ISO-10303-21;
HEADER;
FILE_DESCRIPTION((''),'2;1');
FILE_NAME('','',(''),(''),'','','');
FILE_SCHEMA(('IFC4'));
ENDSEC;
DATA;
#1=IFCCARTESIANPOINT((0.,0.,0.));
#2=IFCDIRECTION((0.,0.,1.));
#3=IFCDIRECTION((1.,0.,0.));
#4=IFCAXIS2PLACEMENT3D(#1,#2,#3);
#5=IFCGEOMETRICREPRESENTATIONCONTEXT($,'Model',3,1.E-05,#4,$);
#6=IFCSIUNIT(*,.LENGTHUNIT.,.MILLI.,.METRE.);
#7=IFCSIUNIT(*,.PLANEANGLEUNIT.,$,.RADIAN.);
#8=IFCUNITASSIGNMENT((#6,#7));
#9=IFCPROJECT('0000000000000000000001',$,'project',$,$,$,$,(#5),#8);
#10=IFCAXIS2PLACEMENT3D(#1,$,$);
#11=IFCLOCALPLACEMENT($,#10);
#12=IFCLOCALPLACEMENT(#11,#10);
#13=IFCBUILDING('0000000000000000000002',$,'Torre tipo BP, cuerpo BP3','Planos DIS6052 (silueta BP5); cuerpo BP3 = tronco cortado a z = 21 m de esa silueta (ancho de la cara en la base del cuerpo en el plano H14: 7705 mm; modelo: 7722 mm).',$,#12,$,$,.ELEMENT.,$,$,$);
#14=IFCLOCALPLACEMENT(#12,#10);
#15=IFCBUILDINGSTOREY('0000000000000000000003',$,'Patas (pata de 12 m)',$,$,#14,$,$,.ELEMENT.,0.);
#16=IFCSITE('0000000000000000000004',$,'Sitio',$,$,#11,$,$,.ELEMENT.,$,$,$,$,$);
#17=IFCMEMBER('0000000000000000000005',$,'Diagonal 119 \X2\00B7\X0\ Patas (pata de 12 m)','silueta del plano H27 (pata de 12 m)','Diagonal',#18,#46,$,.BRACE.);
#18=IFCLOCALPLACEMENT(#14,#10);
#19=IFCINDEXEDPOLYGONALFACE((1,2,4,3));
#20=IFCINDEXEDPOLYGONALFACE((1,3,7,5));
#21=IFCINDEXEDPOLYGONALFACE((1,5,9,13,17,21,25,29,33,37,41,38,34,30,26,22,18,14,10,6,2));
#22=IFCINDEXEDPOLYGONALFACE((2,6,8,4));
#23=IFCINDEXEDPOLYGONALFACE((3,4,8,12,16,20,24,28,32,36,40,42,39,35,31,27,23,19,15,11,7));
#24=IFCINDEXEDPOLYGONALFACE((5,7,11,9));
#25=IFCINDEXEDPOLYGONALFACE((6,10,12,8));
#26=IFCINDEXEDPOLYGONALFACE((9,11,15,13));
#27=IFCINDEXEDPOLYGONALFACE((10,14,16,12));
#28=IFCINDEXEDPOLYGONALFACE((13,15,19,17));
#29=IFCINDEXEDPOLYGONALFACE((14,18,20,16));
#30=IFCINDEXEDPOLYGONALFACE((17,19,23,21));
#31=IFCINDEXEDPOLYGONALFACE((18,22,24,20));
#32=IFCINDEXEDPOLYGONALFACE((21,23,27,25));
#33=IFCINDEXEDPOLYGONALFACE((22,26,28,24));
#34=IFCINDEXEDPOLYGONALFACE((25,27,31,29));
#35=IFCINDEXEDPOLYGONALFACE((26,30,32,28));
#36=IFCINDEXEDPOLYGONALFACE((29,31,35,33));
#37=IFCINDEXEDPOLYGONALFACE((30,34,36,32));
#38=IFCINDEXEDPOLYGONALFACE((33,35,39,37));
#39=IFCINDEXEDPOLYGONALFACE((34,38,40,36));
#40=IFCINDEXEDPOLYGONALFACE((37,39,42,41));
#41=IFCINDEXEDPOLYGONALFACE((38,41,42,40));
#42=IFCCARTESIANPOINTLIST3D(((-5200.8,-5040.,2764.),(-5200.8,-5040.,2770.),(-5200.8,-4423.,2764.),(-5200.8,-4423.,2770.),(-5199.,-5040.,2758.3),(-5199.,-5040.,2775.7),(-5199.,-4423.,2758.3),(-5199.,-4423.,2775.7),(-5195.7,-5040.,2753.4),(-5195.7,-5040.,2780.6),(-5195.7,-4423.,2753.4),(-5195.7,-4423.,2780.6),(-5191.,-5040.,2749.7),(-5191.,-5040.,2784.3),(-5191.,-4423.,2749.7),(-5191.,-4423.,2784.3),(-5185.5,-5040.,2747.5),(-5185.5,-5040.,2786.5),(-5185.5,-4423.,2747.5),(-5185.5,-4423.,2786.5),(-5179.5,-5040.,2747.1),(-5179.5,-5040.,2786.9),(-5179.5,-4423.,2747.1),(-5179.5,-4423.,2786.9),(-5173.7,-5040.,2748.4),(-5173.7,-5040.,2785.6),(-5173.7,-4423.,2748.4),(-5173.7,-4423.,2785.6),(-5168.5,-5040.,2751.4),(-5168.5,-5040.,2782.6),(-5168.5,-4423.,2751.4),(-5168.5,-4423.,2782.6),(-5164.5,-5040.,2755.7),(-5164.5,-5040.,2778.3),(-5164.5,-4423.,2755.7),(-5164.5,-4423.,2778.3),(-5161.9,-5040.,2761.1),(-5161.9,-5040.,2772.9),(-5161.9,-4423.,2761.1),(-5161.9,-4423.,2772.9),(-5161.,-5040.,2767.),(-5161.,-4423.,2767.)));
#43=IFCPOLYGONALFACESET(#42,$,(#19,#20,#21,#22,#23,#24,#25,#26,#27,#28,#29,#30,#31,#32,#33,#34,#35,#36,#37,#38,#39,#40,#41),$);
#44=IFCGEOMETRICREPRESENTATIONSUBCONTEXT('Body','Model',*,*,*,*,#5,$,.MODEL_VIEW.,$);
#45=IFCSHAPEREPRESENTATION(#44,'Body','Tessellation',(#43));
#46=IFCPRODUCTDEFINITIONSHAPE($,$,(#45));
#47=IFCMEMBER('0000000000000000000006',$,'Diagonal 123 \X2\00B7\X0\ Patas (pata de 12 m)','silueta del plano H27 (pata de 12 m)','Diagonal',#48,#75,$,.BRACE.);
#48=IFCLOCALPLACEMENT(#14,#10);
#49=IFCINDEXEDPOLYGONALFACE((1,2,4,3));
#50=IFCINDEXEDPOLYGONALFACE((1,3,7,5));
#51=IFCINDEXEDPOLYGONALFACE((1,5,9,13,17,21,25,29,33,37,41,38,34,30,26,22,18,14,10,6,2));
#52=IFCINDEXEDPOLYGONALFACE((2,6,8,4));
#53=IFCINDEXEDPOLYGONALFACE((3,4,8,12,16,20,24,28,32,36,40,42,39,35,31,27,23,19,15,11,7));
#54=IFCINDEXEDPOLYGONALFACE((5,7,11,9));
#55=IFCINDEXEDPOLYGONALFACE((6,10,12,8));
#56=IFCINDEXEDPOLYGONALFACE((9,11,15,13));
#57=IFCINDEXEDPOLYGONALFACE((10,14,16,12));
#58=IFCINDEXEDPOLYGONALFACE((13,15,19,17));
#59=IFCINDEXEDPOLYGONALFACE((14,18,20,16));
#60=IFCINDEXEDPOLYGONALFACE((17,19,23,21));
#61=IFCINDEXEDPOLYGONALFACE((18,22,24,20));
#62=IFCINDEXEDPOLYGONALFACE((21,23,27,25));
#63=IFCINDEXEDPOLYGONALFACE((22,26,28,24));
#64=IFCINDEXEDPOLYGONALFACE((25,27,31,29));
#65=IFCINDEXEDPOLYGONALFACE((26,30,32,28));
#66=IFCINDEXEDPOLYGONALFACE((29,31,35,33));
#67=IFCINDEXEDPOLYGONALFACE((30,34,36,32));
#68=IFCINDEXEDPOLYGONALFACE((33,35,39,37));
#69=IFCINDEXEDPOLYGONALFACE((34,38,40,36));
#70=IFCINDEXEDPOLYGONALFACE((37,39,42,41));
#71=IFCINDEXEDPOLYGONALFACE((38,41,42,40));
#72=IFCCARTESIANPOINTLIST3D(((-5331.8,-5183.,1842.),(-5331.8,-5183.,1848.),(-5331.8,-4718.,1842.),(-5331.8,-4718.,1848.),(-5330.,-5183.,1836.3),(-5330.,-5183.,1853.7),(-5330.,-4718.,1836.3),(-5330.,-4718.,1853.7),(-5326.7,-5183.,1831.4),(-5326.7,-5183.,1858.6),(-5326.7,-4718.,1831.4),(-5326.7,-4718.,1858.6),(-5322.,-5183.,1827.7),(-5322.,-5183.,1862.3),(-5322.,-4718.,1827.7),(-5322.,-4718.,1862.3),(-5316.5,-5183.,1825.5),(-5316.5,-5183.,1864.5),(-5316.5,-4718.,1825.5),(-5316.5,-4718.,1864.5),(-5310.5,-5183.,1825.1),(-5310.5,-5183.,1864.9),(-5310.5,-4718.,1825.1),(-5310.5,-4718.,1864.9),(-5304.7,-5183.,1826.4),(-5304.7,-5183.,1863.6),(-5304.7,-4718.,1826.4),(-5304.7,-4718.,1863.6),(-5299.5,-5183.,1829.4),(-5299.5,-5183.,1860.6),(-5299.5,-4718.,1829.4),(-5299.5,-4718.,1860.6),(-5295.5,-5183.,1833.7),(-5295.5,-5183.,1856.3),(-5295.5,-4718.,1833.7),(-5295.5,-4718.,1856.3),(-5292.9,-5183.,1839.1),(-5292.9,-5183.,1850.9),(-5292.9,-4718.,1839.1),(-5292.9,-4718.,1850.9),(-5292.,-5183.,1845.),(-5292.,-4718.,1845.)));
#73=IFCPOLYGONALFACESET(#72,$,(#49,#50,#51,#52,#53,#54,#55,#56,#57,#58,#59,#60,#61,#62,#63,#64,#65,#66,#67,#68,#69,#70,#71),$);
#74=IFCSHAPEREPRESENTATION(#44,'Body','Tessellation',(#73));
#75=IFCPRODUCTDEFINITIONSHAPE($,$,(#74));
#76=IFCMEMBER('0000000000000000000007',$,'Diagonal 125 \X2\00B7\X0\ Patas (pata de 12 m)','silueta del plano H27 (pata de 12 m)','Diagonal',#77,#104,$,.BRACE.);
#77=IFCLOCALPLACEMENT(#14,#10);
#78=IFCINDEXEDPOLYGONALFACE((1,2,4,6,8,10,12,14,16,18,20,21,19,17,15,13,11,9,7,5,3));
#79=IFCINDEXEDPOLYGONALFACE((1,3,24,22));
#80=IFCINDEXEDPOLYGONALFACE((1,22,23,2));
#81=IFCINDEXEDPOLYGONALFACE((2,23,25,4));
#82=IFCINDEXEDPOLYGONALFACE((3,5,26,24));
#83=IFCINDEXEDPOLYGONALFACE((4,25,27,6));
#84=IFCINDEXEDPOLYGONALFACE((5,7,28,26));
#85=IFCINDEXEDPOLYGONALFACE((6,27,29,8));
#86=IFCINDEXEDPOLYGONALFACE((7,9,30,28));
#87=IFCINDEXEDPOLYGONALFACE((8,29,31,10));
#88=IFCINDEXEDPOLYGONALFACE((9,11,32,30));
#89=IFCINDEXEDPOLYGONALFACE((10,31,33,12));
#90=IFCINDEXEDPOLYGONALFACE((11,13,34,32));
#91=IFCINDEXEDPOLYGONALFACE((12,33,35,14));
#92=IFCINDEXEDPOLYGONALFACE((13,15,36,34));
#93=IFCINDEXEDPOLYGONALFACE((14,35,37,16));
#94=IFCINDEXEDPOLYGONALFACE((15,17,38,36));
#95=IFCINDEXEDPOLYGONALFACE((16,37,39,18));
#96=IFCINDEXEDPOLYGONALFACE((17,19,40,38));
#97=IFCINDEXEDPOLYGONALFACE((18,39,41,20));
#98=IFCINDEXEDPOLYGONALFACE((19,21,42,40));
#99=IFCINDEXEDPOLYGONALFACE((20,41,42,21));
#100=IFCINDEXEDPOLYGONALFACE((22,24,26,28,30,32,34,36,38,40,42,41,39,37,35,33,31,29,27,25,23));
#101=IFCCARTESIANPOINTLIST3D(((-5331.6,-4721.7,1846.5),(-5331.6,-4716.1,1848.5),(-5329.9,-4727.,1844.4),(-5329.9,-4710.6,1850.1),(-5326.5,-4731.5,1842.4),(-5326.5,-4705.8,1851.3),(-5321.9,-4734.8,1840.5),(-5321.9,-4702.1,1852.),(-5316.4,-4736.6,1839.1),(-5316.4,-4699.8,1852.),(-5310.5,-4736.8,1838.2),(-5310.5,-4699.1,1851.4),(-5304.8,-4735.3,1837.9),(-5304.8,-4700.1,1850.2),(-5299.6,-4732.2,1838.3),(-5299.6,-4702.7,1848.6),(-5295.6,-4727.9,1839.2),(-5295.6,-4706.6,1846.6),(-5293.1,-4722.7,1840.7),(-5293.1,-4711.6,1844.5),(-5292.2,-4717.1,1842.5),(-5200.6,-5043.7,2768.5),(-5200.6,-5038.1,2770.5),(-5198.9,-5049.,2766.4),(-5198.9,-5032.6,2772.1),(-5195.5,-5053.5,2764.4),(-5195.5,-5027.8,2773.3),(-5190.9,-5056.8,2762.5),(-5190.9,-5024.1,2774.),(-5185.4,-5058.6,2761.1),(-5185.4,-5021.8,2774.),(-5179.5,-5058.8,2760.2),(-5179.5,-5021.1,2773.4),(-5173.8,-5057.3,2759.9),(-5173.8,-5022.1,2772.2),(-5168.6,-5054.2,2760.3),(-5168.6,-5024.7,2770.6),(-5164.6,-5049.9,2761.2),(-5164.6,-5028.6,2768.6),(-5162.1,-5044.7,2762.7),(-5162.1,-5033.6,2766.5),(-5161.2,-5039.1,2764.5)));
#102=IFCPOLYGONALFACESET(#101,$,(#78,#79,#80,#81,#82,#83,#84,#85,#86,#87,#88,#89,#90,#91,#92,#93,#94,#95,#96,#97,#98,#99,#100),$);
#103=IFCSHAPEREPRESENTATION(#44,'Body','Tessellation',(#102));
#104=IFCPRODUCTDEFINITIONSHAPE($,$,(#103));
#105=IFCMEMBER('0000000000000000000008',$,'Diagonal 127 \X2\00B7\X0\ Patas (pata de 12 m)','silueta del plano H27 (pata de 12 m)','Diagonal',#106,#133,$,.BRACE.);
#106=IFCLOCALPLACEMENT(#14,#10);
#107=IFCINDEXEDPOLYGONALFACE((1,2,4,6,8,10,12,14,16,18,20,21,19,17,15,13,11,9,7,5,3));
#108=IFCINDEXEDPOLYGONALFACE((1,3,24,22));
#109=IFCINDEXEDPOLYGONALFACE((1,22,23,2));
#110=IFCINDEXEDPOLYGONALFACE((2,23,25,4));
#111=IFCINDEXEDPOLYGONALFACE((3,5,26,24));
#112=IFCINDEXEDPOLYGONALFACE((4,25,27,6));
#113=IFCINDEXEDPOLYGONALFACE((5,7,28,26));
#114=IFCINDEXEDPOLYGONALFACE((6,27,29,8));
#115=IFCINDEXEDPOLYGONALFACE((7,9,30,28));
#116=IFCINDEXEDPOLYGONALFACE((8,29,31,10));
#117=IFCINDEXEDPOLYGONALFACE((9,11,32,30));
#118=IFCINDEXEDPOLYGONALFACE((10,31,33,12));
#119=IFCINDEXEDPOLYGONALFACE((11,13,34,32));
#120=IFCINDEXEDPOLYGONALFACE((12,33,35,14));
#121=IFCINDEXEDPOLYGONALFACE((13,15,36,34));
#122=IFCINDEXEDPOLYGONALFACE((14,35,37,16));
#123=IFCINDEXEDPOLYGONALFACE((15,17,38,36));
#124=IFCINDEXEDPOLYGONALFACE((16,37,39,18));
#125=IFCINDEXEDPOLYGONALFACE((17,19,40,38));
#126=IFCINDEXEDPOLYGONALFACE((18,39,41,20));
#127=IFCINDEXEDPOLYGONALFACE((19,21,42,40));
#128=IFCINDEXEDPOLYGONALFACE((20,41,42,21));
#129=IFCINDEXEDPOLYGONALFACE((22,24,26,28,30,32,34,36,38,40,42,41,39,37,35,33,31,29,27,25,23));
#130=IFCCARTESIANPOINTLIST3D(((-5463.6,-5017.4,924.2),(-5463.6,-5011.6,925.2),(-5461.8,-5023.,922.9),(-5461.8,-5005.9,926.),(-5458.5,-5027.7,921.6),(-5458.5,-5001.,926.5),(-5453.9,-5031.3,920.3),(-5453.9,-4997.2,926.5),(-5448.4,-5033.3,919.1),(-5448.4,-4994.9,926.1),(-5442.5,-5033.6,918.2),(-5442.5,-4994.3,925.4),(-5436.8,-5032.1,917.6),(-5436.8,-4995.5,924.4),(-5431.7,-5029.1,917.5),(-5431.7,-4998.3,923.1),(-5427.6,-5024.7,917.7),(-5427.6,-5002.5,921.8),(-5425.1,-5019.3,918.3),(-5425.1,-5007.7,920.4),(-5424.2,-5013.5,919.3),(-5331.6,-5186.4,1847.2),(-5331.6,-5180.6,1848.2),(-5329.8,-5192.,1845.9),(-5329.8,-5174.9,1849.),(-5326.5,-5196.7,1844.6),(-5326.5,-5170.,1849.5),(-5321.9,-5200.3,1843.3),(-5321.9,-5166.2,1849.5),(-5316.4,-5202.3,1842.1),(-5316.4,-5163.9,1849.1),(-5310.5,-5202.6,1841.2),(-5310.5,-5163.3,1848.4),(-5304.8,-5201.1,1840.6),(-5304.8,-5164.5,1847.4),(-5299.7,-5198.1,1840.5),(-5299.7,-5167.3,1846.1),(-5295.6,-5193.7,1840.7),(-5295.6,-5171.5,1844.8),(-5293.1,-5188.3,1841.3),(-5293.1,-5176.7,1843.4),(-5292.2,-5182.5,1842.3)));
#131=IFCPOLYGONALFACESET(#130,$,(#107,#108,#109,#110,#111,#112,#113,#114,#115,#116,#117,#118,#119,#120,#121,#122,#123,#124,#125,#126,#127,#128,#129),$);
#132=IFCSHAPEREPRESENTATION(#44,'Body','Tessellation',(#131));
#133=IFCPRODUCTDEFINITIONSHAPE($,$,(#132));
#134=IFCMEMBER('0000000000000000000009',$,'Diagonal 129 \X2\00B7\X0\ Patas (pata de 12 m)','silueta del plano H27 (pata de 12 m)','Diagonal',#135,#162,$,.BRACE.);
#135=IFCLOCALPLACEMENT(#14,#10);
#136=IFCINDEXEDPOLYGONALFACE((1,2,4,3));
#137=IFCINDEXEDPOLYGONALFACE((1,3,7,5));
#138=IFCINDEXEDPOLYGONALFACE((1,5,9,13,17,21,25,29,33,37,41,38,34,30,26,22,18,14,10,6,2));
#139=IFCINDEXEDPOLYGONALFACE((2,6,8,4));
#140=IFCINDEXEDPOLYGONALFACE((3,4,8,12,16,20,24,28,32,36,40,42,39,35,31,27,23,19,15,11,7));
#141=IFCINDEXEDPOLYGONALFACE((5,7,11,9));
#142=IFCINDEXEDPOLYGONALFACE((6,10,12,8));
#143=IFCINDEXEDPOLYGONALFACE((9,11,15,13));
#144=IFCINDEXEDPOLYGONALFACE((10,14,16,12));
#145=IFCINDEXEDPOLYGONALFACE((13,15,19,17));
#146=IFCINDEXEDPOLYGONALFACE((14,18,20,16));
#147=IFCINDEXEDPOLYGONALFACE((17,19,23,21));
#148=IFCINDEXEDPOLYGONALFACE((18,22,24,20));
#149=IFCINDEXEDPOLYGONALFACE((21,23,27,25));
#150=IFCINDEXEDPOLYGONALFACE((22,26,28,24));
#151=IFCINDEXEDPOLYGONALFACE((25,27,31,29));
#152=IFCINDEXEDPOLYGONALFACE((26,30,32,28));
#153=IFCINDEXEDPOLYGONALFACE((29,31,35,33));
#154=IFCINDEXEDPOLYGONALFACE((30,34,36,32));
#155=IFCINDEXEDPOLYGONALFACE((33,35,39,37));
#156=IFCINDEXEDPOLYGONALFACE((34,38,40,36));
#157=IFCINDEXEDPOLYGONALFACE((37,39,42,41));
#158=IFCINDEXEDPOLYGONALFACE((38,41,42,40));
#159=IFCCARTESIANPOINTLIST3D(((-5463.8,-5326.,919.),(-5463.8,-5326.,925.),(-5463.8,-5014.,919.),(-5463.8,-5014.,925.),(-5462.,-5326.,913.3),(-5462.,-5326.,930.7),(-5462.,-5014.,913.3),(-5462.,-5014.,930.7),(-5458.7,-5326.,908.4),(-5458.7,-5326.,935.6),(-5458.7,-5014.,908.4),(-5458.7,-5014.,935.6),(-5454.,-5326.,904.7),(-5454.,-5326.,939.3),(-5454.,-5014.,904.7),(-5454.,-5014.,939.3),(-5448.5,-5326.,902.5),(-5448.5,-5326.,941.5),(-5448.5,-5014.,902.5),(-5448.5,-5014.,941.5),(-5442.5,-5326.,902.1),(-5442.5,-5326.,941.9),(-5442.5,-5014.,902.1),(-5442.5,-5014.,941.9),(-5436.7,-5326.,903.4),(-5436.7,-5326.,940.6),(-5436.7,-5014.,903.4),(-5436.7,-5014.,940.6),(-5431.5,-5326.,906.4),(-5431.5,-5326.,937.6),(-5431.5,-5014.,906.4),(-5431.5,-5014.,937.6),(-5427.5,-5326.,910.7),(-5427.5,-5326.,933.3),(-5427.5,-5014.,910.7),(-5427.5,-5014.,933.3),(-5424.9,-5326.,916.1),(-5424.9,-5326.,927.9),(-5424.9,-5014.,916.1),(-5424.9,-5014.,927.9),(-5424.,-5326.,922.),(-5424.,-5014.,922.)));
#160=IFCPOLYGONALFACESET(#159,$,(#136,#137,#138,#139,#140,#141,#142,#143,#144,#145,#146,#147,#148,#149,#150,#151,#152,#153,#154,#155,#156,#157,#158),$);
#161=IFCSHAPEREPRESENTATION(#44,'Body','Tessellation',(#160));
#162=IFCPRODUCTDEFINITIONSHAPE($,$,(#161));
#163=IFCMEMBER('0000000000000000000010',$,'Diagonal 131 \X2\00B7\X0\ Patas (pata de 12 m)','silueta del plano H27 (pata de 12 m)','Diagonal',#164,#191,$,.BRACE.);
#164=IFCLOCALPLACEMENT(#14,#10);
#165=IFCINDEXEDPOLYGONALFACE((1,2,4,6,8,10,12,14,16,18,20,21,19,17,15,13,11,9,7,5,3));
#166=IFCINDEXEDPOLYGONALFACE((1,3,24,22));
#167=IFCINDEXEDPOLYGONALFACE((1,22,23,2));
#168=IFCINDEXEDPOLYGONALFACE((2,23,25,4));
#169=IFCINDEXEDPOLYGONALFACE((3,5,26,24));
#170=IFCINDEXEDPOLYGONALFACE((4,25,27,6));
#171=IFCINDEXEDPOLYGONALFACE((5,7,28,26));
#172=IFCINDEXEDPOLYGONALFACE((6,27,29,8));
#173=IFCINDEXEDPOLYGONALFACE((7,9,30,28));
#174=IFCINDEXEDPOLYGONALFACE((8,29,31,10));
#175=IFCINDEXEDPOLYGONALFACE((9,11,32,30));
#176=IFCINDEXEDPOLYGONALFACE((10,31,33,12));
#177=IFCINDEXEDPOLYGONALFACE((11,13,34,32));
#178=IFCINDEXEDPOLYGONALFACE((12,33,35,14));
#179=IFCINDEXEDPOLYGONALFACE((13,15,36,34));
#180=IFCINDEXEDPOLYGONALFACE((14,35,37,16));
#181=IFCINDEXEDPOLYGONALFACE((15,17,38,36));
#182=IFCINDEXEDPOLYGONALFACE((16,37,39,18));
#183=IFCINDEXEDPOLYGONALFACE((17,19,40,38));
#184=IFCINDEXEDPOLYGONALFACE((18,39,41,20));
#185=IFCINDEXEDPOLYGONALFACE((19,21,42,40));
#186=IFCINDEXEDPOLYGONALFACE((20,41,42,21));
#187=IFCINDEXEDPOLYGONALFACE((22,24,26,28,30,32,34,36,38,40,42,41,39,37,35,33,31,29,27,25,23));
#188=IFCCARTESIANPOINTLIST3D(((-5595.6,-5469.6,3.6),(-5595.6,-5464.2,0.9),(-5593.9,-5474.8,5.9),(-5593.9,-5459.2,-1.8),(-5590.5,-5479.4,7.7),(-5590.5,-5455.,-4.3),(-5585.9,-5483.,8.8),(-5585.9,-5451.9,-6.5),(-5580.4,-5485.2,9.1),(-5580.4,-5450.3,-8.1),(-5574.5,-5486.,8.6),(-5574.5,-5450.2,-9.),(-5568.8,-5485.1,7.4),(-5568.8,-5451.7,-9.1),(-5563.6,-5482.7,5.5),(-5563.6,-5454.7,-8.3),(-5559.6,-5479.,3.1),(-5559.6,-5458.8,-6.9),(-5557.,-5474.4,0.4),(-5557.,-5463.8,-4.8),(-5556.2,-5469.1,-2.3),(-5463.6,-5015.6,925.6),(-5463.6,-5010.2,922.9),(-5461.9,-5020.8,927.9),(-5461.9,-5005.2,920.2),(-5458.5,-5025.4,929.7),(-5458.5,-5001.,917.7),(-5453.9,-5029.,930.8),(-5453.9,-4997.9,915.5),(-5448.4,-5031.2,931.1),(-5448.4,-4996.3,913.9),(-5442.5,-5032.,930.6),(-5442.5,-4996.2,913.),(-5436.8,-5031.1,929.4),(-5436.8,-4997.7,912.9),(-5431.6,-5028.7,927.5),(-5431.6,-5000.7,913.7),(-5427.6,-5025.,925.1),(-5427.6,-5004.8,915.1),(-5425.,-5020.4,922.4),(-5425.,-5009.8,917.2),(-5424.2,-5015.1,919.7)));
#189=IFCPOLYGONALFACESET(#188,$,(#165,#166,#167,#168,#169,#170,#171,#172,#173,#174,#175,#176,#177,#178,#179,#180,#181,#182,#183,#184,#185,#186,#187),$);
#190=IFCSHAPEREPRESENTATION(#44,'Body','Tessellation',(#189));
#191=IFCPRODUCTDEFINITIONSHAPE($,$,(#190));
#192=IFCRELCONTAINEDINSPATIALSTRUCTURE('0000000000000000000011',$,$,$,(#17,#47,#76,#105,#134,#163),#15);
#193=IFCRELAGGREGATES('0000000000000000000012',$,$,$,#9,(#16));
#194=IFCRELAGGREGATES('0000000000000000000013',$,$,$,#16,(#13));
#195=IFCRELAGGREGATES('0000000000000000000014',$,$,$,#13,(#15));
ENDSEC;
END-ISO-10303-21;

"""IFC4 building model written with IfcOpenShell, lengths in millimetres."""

from ifc_helpers import new_model, si_unit, frame, origin, origin_with_axes, place, context, subcontext, project, spatial, circle, extrude, element, save


model = new_model("IFC4")

# Units and contexts
model_context = context("Model", 3, precision=1e-05, world=origin_with_axes())
body_context = subcontext(model_context, "Body", "Model", "MODEL_VIEW")
ifc_project = project(units=[si_unit("LENGTHUNIT", "METRE", prefix="MILLI"), si_unit("PLANEANGLEUNIT", "RADIAN")], contexts=[model_context])

# Site, building, storey
site_placement = place(None, origin())
site = spatial("IfcSite", under=ifc_project, at=site_placement, Name="Sitio", CompositionType="ELEMENT")
building_placement = place(site_placement, origin())
building = spatial("IfcBuilding", under=site, at=building_placement, Name="Torre tipo BP, cuerpo BP3", Description="Planos DIS6052 (silueta BP5); cuerpo BP3 = tronco cortado a z = 21 m de esa silueta (ancho de la cara en la base del cuerpo en el plano H14: 7705 mm; modelo: 7722 mm).", CompositionType="ELEMENT")
storey_placement = place(building_placement, origin())
storey = spatial("IfcBuildingStorey", under=building, at=storey_placement, Name="Patas (pata de 12 m)", CompositionType="ELEMENT", Elevation=0.0)

# Members
member_1_placement = place(storey_placement, frame((-5181.0, -5040.0, 2767.0), z_axis=(0.0, 1.0, 0.0), x_axis=(1.0, 0.0, 0.0)))
element("IfcMember", 1, at=member_1_placement, inside=storey, Name="Diagonal 119 · Patas (pata de 12 m)", Description="silueta del plano H27 (pata de 12 m)", ObjectType="Diagonal", PredefinedType="BRACE", context=body_context, shape_type="SweptSolid", body=[
    extrude(circle(Radius=20.0), None, (0.0, 0.0, 1.0), 617.0),
])
member_2_placement = place(storey_placement, frame((-5312.0, -5183.0, 1845.0), z_axis=(0.0, 1.0, 0.0), x_axis=(1.0, 0.0, 0.0)))
element("IfcMember", 2, at=member_2_placement, inside=storey, Name="Diagonal 123 · Patas (pata de 12 m)", Description="silueta del plano H27 (pata de 12 m)", ObjectType="Diagonal", PredefinedType="BRACE", context=body_context, shape_type="SweptSolid", body=[
    extrude(circle(Radius=20.0), None, (0.0, 0.0, 1.0), 465.0),
])
member_3_placement = place(storey_placement, frame((-5312.0, -4718.0, 1845.0), z_axis=(0.132947, -0.326785, 0.935701), x_axis=(0.991123, 0.043834, -0.125513)))
element("IfcMember", 3, at=member_3_placement, inside=storey, Name="Diagonal 125 · Patas (pata de 12 m)", Description="silueta del plano H27 (pata de 12 m)", ObjectType="Diagonal", PredefinedType="BRACE", context=body_context, shape_type="SweptSolid", body=[
    extrude(circle(Radius=20.0), None, (0.0, 0.0, 1.0), 985.4),
])
member_4_placement = place(storey_placement, frame((-5444.0, -5014.0, 922.0), z_axis=(0.139302, -0.178348, 0.974057), x_axis=(0.99025, 0.025089, -0.137024)))
element("IfcMember", 4, at=member_4_placement, inside=storey, Name="Diagonal 127 · Patas (pata de 12 m)", Description="silueta del plano H27 (pata de 12 m)", ObjectType="Diagonal", PredefinedType="BRACE", context=body_context, shape_type="SweptSolid", body=[
    extrude(circle(Radius=20.0), None, (0.0, 0.0, 1.0), 947.6),
])
member_5_placement = place(storey_placement, frame((-5444.0, -5326.0, 922.0), z_axis=(0.0, 1.0, 0.0), x_axis=(1.0, 0.0, 0.0)))
element("IfcMember", 5, at=member_5_placement, inside=storey, Name="Diagonal 129 · Patas (pata de 12 m)", Description="silueta del plano H27 (pata de 12 m)", ObjectType="Diagonal", PredefinedType="BRACE", context=body_context, shape_type="SweptSolid", body=[
    extrude(circle(Radius=20.0), None, (0.0, 0.0, 1.0), 312.0),
])
member_6_placement = place(storey_placement, frame((-5576.0, -5468.0, 0.0), z_axis=(0.127394, 0.438157, 0.889825), x_axis=(0.991852, -0.056277, -0.114289)))
element("IfcMember", 6, at=member_6_placement, inside=storey, Name="Diagonal 131 · Patas (pata de 12 m)", Description="silueta del plano H27 (pata de 12 m)", ObjectType="Diagonal", PredefinedType="BRACE", context=body_context, shape_type="SweptSolid", body=[
    extrude(circle(Radius=20.0), None, (0.0, 0.0, 1.0), 1036.2),
])

save(model, "model.ifc")
